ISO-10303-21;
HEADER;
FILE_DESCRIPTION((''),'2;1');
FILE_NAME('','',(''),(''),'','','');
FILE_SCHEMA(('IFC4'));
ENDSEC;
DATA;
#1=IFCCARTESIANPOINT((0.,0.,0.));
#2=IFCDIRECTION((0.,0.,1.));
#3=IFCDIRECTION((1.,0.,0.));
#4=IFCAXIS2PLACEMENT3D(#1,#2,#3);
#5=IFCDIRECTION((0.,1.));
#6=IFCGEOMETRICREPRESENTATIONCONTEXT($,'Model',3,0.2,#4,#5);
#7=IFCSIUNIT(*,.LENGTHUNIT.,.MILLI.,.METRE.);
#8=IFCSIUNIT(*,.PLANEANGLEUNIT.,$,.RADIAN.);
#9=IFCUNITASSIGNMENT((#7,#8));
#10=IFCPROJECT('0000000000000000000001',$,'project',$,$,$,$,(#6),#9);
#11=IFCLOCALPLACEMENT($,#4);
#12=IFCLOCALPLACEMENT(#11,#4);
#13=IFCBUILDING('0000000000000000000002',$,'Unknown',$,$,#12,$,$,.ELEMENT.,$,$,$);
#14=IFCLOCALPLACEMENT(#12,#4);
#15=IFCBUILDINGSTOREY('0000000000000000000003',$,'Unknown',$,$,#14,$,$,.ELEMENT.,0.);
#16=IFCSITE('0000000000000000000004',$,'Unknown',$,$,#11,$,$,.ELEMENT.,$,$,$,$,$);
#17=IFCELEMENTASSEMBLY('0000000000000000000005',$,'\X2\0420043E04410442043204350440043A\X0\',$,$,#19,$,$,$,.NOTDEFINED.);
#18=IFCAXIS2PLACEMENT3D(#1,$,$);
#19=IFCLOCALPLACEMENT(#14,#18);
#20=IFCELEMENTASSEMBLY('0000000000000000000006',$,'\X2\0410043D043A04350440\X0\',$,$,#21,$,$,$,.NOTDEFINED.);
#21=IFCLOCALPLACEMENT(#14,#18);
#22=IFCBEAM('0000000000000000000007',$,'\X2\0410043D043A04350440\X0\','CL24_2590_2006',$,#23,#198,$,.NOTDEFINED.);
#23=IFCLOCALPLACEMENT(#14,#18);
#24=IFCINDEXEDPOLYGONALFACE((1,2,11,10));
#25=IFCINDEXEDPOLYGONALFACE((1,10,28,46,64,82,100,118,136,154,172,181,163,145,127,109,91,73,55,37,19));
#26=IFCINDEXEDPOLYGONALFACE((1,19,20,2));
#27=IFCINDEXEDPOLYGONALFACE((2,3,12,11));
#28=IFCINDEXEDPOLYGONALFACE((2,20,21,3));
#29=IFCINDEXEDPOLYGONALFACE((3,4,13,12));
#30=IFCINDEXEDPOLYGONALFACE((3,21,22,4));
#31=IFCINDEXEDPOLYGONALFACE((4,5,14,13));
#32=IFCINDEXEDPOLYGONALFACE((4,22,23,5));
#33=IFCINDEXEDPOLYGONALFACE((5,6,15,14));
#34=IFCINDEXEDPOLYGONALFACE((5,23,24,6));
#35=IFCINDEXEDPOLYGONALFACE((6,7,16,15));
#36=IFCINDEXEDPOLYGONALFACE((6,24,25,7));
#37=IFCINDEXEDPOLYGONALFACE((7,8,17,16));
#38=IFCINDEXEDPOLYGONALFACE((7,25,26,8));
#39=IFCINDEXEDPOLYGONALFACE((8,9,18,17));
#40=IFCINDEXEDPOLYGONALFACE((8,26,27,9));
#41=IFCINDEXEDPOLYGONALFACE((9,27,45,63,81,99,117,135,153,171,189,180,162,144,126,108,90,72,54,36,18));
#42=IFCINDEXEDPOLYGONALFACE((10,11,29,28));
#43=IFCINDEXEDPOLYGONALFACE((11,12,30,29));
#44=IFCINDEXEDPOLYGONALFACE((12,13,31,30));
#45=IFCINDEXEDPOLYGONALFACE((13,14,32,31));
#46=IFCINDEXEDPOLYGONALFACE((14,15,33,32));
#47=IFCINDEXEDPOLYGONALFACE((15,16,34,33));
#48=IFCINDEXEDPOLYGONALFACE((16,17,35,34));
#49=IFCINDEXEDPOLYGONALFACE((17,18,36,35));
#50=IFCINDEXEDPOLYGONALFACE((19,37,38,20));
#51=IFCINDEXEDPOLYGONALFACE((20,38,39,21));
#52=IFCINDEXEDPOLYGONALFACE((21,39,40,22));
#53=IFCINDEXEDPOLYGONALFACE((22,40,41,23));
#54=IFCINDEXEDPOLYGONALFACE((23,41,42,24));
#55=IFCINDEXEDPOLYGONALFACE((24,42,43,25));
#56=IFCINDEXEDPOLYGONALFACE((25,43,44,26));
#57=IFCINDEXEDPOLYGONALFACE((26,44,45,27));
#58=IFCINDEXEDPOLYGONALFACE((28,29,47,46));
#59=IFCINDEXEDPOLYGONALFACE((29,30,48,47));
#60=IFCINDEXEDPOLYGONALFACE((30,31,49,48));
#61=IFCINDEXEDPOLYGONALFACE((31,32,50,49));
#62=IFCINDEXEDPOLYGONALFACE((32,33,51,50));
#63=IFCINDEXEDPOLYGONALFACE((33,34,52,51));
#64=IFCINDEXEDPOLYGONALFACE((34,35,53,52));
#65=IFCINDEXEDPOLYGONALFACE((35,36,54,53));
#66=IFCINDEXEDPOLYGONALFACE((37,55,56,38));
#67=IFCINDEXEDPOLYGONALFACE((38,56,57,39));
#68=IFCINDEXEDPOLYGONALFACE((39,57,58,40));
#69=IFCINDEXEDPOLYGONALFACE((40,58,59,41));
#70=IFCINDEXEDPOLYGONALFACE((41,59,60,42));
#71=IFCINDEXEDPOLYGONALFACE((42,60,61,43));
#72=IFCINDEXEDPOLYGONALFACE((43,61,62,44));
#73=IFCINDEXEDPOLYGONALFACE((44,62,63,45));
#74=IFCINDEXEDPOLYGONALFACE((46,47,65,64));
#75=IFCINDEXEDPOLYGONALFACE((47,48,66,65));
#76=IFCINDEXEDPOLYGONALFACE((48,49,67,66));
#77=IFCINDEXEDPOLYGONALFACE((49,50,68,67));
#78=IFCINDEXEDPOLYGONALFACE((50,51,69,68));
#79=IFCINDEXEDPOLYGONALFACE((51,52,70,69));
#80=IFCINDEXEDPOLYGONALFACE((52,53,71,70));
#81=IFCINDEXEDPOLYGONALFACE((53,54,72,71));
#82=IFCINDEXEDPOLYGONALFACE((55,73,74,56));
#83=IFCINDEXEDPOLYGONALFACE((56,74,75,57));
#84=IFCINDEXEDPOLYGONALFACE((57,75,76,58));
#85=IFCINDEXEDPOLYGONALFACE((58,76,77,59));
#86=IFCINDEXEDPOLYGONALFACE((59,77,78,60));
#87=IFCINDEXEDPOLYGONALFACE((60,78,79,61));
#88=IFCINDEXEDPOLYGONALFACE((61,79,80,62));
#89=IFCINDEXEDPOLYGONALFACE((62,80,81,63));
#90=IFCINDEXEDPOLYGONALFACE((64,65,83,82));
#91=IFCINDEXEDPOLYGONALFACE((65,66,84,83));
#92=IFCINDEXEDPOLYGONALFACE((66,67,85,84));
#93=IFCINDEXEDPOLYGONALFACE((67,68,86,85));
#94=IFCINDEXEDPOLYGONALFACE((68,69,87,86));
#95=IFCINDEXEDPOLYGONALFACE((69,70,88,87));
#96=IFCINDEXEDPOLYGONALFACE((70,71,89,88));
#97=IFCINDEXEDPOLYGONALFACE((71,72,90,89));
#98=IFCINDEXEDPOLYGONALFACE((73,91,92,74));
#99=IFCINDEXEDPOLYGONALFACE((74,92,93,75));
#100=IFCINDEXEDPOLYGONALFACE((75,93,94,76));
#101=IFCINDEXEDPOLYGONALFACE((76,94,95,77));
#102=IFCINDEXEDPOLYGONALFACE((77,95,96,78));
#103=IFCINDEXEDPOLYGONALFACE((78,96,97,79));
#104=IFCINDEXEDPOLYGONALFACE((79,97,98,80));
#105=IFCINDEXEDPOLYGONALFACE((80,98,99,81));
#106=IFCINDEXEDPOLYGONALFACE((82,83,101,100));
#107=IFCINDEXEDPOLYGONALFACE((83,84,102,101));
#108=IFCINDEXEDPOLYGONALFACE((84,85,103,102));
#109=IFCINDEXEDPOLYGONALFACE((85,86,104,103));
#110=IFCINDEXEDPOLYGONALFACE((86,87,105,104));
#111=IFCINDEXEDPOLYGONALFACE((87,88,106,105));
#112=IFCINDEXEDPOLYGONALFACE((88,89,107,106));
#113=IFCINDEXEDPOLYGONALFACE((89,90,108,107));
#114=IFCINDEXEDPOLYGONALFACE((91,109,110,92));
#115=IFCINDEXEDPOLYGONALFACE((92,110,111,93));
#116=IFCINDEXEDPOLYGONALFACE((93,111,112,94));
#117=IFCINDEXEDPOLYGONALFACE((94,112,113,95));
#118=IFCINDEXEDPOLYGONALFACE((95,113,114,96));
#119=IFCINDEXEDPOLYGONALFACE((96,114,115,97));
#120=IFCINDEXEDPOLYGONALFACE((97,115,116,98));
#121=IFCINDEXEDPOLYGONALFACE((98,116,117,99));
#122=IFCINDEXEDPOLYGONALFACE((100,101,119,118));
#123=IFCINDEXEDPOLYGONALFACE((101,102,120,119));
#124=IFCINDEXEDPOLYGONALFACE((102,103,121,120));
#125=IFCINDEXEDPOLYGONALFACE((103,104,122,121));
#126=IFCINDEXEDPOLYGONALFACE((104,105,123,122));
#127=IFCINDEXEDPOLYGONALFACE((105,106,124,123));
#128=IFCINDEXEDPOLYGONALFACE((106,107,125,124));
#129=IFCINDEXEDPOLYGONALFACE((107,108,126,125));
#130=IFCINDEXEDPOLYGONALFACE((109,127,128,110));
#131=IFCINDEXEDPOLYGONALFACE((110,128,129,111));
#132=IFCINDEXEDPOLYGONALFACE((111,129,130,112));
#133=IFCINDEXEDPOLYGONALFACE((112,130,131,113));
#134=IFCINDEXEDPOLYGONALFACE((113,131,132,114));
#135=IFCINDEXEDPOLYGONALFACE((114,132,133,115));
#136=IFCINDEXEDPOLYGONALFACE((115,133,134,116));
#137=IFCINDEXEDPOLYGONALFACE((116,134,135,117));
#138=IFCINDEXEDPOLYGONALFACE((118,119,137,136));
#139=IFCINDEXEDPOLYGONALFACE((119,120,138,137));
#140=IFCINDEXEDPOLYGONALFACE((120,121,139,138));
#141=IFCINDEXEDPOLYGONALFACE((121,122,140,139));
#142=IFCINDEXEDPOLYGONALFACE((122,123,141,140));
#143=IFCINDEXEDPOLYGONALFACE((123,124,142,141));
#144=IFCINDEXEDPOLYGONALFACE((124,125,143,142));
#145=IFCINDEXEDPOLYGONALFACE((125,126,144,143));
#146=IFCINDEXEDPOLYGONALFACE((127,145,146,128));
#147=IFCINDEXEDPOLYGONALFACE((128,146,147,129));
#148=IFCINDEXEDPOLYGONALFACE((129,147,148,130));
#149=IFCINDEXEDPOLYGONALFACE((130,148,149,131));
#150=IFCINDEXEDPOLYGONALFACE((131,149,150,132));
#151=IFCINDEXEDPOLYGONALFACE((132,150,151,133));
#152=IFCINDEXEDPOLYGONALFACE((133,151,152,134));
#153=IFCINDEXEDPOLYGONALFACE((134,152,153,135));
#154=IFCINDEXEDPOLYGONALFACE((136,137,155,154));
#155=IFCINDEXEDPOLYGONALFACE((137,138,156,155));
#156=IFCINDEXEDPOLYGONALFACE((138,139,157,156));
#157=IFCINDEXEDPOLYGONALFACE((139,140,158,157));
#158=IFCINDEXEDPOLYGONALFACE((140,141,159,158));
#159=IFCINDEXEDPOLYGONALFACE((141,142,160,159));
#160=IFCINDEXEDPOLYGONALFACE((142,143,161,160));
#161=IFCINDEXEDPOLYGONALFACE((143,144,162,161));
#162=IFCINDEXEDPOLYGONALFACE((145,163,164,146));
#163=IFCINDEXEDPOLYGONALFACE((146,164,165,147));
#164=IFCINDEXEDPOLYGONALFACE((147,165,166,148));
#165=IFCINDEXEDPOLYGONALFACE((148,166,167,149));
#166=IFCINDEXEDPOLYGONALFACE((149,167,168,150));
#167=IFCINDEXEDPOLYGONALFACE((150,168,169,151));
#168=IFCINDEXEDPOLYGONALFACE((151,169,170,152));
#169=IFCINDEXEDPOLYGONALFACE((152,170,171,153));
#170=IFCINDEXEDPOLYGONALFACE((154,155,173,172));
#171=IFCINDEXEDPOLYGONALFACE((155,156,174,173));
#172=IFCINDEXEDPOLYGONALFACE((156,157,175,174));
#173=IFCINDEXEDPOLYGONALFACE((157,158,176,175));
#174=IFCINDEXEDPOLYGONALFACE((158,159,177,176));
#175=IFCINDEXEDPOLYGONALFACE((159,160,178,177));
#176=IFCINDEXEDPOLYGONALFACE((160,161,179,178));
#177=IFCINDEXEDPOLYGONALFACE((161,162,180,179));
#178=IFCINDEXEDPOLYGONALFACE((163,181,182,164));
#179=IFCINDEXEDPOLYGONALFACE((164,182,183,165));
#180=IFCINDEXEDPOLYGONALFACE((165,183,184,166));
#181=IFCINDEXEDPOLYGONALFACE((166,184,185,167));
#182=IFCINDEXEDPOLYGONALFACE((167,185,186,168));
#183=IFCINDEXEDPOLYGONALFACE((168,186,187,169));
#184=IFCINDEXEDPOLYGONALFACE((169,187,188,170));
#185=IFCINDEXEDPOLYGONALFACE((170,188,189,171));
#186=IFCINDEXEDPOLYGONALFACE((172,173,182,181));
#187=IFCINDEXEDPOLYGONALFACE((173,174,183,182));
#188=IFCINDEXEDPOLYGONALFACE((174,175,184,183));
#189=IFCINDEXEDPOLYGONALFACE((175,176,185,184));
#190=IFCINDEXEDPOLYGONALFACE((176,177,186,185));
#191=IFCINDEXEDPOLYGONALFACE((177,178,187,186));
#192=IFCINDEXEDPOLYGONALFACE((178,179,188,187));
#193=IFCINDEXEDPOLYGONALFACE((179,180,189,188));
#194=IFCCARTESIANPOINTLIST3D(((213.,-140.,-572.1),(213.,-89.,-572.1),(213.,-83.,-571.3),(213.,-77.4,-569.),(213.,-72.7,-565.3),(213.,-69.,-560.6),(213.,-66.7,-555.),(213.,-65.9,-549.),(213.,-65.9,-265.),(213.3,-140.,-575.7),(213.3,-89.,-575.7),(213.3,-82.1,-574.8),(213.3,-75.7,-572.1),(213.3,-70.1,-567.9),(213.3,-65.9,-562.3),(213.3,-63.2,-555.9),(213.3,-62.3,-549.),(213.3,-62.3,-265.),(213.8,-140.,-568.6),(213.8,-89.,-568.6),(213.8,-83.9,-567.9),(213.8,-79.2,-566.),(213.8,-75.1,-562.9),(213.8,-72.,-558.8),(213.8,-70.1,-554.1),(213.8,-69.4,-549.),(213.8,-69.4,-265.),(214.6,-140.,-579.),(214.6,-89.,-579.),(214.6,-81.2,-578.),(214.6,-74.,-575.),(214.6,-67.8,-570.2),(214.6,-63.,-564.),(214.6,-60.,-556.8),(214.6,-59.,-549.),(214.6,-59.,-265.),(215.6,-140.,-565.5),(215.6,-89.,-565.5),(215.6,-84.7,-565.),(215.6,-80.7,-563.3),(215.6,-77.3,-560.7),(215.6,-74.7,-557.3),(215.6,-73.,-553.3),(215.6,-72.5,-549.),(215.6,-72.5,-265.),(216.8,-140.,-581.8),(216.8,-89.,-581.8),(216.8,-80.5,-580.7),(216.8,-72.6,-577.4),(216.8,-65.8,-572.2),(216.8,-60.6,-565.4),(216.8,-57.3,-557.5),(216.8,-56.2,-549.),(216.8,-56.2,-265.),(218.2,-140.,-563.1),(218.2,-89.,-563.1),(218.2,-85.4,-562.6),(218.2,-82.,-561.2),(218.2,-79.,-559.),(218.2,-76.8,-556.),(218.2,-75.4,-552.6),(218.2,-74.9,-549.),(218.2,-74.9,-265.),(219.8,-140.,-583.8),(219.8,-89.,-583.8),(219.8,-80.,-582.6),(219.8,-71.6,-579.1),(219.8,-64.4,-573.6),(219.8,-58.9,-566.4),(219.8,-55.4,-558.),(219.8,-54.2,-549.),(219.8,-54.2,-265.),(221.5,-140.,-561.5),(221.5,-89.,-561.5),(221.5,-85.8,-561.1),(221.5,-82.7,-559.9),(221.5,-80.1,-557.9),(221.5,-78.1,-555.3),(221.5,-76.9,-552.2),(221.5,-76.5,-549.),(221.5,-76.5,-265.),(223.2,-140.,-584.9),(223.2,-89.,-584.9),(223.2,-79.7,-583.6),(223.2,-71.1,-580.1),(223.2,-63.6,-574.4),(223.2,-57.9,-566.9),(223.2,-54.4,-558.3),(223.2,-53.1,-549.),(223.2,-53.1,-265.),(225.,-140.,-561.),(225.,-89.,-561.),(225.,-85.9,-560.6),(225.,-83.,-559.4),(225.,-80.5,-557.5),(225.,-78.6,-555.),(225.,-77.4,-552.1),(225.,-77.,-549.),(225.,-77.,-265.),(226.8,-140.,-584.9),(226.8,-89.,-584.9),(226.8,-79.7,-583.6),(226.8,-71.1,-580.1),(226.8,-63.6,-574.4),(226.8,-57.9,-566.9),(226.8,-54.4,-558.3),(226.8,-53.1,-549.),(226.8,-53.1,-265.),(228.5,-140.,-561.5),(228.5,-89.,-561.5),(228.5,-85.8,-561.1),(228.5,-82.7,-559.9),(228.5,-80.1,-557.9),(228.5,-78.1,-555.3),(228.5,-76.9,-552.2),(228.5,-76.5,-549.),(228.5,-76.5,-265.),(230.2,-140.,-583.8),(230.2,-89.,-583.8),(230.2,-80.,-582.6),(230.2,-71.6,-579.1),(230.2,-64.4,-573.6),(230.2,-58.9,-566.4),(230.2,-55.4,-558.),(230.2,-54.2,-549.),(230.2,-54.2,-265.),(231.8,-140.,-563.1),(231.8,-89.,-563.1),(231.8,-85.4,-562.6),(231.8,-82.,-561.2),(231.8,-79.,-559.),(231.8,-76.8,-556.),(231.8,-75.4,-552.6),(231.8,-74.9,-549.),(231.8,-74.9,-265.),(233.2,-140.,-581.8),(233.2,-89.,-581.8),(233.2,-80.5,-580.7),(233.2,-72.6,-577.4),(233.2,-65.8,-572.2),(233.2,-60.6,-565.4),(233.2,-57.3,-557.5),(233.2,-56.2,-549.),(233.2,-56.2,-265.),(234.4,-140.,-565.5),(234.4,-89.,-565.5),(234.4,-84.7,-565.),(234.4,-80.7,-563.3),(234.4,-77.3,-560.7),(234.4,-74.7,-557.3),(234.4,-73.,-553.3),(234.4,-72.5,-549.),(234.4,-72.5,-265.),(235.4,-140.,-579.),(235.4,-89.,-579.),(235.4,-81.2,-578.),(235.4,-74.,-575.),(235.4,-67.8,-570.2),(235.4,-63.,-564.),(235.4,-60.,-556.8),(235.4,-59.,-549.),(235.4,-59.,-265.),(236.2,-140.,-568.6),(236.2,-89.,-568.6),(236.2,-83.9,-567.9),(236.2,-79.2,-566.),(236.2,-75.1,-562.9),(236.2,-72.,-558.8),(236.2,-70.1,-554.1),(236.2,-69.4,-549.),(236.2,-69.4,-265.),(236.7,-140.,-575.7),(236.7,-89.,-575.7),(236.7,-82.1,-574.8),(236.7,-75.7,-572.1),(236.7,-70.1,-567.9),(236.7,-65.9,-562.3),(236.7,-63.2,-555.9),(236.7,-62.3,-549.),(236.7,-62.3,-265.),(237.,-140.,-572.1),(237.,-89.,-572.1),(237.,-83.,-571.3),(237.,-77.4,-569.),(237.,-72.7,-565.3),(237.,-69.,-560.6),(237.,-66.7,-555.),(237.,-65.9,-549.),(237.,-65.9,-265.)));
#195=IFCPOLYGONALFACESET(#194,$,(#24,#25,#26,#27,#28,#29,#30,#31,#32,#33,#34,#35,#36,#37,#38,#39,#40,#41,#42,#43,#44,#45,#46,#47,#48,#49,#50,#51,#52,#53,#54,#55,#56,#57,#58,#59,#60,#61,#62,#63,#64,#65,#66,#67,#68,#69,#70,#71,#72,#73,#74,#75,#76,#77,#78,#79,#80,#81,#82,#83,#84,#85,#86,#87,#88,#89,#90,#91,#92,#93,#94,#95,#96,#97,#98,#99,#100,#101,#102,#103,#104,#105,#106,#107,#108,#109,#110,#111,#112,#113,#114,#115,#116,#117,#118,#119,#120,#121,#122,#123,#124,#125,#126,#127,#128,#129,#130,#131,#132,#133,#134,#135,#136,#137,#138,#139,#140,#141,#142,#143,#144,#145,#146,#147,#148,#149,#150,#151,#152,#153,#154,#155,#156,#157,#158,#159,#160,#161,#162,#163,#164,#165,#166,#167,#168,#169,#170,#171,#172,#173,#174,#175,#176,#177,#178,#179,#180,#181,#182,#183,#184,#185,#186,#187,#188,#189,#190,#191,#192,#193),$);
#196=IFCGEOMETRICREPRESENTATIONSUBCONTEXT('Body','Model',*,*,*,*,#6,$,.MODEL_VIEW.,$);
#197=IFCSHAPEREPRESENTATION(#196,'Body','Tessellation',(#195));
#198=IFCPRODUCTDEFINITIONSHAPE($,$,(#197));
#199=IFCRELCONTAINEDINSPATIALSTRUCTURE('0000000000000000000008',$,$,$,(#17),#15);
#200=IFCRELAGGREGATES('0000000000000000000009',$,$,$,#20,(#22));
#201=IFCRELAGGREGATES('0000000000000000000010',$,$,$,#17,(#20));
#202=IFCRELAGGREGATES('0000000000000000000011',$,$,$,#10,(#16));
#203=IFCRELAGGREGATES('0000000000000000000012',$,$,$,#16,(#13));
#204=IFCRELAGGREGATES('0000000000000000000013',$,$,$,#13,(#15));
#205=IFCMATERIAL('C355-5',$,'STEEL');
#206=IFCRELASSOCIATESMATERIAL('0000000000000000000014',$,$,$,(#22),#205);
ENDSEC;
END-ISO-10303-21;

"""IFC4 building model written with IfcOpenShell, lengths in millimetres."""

from ifc_helpers import new_model, entity, si_unit, direction, frame, origin_with_axes, place, context, subcontext, project, spatial, line, indexed_curve, outline, extrude, material, element, aggregate, save


model = new_model("IFC4")

# Units and contexts
model_context = context("Model", 3, precision=0.2, world=origin_with_axes(), true_north=direction((0.0, 1.0)))
body_context = subcontext(model_context, "Body", "Model", "MODEL_VIEW")
ifc_project = project(units=[si_unit("LENGTHUNIT", "METRE", prefix="MILLI"), si_unit("PLANEANGLEUNIT", "RADIAN")], contexts=[model_context])

# Site, building, storey
site_placement = place(None, origin_with_axes())
site = spatial("IfcSite", under=ifc_project, at=site_placement, Name="Unknown", CompositionType="ELEMENT")
building_placement = place(site_placement, origin_with_axes())
building = spatial("IfcBuilding", under=site, at=building_placement, Name="Unknown", CompositionType="ELEMENT")
storey_placement = place(building_placement, origin_with_axes())
storey = spatial("IfcBuildingStorey", under=building, at=storey_placement, Name="Unknown", CompositionType="ELEMENT", Elevation=0.0)

# Element assemblies, beam, voiding feature
assembly_1_placement = place(storey_placement, frame((80.0, 80.0, -300.0), z_axis=(0.0, -1.0, 0.0), x_axis=(0.0, 0.0, -1.0)))
assembly_1 = element("IfcElementAssembly", 1, at=assembly_1_placement, inside=storey, Name="Ростверк", PredefinedType="NOTDEFINED")
assembly_2_placement = place(assembly_1_placement, frame((-215.0, 145.0, 145.0), z_axis=(0.0, 0.0, 1.0), x_axis=(1.0, 0.0, 0.0)))
assembly_2 = element("IfcElementAssembly", 2, at=assembly_2_placement, Name="Анкер", PredefinedType="NOTDEFINED")
ifc_material_1 = material(Name="C355-5", Category="STEEL")
beam_1_placement = place(assembly_2_placement, origin_with_axes())
beam_1 = element("IfcBeam", 3, at=beam_1_placement, material=ifc_material_1, Name="Анкер", Description="CL24_2590_2006", PredefinedType="NOTDEFINED", context=body_context, shape_type="SolidModel", body=[
    entity("IfcSweptDiskSolid", entity("IfcIndexedPolyCurve", entity("IfcCartesianPointList3D", [[0.0, 0.0, 0.0], [464.0, 0.0, 0.0], [481.0, 0.0, 7.0], [488.0, 0.0, 24.0], [488.0, 0.0, 75.0]]), [entity("IfcLineIndex", [1, 2]), entity("IfcArcIndex", [2, 3, 4]), entity("IfcLineIndex", [4, 5])]), 12.0),
])
voiding_feature_1_placement = place(beam_1_placement, frame((0.0, 0.0, 0.0), z_axis=(0.0, -1.0, 0.0), x_axis=(1.0, 0.0, 0.0)))
element("IfcVoidingFeature", 4, at=voiding_feature_1_placement, cuts=beam_1, Name="Анкер", PredefinedType="HOLE", context=body_context, shape_type="SolidModel", body=[
    extrude(outline(indexed_curve([(12.5, 0.0), (12.2, 2.8), (11.3, 5.4), (9.8, 7.8), (7.8, 9.8), (5.4, 11.3), (2.8, 12.2), (0.0, 12.5), (-2.8, 12.2), (-5.4, 11.3), (-7.8, 9.8), (-9.8, 7.8), (-11.3, 5.4), (-12.2, 2.8), (-12.5, 0.0), (-12.2, -2.8), (-11.3, -5.4), (-9.8, -7.8), (-7.8, -9.8), (-5.4, -11.3), (-2.8, -12.2), (0.0, -12.5), (2.8, -12.2), (5.4, -11.3), (7.8, -9.8), (9.8, -7.8), (11.3, -5.4), (12.2, -2.8)], segments=[line(1, 2, 3, 4, 5, 6, 7, 8, 9, 10, 11, 12, 13, 14, 15, 16, 17, 18, 19, 20, 21, 22, 23, 24, 25, 26, 27, 28, 1)])), frame((0.0, 0.0, 0.0), z_axis=(-1.0, 0.0, 0.0), x_axis=(0.0, 0.0, 1.0)), (0.0, 0.0, -1.0), 180.0),
])
aggregate(assembly_2, [beam_1])
aggregate(assembly_1, [assembly_2])

save(model, "model.ifc")
